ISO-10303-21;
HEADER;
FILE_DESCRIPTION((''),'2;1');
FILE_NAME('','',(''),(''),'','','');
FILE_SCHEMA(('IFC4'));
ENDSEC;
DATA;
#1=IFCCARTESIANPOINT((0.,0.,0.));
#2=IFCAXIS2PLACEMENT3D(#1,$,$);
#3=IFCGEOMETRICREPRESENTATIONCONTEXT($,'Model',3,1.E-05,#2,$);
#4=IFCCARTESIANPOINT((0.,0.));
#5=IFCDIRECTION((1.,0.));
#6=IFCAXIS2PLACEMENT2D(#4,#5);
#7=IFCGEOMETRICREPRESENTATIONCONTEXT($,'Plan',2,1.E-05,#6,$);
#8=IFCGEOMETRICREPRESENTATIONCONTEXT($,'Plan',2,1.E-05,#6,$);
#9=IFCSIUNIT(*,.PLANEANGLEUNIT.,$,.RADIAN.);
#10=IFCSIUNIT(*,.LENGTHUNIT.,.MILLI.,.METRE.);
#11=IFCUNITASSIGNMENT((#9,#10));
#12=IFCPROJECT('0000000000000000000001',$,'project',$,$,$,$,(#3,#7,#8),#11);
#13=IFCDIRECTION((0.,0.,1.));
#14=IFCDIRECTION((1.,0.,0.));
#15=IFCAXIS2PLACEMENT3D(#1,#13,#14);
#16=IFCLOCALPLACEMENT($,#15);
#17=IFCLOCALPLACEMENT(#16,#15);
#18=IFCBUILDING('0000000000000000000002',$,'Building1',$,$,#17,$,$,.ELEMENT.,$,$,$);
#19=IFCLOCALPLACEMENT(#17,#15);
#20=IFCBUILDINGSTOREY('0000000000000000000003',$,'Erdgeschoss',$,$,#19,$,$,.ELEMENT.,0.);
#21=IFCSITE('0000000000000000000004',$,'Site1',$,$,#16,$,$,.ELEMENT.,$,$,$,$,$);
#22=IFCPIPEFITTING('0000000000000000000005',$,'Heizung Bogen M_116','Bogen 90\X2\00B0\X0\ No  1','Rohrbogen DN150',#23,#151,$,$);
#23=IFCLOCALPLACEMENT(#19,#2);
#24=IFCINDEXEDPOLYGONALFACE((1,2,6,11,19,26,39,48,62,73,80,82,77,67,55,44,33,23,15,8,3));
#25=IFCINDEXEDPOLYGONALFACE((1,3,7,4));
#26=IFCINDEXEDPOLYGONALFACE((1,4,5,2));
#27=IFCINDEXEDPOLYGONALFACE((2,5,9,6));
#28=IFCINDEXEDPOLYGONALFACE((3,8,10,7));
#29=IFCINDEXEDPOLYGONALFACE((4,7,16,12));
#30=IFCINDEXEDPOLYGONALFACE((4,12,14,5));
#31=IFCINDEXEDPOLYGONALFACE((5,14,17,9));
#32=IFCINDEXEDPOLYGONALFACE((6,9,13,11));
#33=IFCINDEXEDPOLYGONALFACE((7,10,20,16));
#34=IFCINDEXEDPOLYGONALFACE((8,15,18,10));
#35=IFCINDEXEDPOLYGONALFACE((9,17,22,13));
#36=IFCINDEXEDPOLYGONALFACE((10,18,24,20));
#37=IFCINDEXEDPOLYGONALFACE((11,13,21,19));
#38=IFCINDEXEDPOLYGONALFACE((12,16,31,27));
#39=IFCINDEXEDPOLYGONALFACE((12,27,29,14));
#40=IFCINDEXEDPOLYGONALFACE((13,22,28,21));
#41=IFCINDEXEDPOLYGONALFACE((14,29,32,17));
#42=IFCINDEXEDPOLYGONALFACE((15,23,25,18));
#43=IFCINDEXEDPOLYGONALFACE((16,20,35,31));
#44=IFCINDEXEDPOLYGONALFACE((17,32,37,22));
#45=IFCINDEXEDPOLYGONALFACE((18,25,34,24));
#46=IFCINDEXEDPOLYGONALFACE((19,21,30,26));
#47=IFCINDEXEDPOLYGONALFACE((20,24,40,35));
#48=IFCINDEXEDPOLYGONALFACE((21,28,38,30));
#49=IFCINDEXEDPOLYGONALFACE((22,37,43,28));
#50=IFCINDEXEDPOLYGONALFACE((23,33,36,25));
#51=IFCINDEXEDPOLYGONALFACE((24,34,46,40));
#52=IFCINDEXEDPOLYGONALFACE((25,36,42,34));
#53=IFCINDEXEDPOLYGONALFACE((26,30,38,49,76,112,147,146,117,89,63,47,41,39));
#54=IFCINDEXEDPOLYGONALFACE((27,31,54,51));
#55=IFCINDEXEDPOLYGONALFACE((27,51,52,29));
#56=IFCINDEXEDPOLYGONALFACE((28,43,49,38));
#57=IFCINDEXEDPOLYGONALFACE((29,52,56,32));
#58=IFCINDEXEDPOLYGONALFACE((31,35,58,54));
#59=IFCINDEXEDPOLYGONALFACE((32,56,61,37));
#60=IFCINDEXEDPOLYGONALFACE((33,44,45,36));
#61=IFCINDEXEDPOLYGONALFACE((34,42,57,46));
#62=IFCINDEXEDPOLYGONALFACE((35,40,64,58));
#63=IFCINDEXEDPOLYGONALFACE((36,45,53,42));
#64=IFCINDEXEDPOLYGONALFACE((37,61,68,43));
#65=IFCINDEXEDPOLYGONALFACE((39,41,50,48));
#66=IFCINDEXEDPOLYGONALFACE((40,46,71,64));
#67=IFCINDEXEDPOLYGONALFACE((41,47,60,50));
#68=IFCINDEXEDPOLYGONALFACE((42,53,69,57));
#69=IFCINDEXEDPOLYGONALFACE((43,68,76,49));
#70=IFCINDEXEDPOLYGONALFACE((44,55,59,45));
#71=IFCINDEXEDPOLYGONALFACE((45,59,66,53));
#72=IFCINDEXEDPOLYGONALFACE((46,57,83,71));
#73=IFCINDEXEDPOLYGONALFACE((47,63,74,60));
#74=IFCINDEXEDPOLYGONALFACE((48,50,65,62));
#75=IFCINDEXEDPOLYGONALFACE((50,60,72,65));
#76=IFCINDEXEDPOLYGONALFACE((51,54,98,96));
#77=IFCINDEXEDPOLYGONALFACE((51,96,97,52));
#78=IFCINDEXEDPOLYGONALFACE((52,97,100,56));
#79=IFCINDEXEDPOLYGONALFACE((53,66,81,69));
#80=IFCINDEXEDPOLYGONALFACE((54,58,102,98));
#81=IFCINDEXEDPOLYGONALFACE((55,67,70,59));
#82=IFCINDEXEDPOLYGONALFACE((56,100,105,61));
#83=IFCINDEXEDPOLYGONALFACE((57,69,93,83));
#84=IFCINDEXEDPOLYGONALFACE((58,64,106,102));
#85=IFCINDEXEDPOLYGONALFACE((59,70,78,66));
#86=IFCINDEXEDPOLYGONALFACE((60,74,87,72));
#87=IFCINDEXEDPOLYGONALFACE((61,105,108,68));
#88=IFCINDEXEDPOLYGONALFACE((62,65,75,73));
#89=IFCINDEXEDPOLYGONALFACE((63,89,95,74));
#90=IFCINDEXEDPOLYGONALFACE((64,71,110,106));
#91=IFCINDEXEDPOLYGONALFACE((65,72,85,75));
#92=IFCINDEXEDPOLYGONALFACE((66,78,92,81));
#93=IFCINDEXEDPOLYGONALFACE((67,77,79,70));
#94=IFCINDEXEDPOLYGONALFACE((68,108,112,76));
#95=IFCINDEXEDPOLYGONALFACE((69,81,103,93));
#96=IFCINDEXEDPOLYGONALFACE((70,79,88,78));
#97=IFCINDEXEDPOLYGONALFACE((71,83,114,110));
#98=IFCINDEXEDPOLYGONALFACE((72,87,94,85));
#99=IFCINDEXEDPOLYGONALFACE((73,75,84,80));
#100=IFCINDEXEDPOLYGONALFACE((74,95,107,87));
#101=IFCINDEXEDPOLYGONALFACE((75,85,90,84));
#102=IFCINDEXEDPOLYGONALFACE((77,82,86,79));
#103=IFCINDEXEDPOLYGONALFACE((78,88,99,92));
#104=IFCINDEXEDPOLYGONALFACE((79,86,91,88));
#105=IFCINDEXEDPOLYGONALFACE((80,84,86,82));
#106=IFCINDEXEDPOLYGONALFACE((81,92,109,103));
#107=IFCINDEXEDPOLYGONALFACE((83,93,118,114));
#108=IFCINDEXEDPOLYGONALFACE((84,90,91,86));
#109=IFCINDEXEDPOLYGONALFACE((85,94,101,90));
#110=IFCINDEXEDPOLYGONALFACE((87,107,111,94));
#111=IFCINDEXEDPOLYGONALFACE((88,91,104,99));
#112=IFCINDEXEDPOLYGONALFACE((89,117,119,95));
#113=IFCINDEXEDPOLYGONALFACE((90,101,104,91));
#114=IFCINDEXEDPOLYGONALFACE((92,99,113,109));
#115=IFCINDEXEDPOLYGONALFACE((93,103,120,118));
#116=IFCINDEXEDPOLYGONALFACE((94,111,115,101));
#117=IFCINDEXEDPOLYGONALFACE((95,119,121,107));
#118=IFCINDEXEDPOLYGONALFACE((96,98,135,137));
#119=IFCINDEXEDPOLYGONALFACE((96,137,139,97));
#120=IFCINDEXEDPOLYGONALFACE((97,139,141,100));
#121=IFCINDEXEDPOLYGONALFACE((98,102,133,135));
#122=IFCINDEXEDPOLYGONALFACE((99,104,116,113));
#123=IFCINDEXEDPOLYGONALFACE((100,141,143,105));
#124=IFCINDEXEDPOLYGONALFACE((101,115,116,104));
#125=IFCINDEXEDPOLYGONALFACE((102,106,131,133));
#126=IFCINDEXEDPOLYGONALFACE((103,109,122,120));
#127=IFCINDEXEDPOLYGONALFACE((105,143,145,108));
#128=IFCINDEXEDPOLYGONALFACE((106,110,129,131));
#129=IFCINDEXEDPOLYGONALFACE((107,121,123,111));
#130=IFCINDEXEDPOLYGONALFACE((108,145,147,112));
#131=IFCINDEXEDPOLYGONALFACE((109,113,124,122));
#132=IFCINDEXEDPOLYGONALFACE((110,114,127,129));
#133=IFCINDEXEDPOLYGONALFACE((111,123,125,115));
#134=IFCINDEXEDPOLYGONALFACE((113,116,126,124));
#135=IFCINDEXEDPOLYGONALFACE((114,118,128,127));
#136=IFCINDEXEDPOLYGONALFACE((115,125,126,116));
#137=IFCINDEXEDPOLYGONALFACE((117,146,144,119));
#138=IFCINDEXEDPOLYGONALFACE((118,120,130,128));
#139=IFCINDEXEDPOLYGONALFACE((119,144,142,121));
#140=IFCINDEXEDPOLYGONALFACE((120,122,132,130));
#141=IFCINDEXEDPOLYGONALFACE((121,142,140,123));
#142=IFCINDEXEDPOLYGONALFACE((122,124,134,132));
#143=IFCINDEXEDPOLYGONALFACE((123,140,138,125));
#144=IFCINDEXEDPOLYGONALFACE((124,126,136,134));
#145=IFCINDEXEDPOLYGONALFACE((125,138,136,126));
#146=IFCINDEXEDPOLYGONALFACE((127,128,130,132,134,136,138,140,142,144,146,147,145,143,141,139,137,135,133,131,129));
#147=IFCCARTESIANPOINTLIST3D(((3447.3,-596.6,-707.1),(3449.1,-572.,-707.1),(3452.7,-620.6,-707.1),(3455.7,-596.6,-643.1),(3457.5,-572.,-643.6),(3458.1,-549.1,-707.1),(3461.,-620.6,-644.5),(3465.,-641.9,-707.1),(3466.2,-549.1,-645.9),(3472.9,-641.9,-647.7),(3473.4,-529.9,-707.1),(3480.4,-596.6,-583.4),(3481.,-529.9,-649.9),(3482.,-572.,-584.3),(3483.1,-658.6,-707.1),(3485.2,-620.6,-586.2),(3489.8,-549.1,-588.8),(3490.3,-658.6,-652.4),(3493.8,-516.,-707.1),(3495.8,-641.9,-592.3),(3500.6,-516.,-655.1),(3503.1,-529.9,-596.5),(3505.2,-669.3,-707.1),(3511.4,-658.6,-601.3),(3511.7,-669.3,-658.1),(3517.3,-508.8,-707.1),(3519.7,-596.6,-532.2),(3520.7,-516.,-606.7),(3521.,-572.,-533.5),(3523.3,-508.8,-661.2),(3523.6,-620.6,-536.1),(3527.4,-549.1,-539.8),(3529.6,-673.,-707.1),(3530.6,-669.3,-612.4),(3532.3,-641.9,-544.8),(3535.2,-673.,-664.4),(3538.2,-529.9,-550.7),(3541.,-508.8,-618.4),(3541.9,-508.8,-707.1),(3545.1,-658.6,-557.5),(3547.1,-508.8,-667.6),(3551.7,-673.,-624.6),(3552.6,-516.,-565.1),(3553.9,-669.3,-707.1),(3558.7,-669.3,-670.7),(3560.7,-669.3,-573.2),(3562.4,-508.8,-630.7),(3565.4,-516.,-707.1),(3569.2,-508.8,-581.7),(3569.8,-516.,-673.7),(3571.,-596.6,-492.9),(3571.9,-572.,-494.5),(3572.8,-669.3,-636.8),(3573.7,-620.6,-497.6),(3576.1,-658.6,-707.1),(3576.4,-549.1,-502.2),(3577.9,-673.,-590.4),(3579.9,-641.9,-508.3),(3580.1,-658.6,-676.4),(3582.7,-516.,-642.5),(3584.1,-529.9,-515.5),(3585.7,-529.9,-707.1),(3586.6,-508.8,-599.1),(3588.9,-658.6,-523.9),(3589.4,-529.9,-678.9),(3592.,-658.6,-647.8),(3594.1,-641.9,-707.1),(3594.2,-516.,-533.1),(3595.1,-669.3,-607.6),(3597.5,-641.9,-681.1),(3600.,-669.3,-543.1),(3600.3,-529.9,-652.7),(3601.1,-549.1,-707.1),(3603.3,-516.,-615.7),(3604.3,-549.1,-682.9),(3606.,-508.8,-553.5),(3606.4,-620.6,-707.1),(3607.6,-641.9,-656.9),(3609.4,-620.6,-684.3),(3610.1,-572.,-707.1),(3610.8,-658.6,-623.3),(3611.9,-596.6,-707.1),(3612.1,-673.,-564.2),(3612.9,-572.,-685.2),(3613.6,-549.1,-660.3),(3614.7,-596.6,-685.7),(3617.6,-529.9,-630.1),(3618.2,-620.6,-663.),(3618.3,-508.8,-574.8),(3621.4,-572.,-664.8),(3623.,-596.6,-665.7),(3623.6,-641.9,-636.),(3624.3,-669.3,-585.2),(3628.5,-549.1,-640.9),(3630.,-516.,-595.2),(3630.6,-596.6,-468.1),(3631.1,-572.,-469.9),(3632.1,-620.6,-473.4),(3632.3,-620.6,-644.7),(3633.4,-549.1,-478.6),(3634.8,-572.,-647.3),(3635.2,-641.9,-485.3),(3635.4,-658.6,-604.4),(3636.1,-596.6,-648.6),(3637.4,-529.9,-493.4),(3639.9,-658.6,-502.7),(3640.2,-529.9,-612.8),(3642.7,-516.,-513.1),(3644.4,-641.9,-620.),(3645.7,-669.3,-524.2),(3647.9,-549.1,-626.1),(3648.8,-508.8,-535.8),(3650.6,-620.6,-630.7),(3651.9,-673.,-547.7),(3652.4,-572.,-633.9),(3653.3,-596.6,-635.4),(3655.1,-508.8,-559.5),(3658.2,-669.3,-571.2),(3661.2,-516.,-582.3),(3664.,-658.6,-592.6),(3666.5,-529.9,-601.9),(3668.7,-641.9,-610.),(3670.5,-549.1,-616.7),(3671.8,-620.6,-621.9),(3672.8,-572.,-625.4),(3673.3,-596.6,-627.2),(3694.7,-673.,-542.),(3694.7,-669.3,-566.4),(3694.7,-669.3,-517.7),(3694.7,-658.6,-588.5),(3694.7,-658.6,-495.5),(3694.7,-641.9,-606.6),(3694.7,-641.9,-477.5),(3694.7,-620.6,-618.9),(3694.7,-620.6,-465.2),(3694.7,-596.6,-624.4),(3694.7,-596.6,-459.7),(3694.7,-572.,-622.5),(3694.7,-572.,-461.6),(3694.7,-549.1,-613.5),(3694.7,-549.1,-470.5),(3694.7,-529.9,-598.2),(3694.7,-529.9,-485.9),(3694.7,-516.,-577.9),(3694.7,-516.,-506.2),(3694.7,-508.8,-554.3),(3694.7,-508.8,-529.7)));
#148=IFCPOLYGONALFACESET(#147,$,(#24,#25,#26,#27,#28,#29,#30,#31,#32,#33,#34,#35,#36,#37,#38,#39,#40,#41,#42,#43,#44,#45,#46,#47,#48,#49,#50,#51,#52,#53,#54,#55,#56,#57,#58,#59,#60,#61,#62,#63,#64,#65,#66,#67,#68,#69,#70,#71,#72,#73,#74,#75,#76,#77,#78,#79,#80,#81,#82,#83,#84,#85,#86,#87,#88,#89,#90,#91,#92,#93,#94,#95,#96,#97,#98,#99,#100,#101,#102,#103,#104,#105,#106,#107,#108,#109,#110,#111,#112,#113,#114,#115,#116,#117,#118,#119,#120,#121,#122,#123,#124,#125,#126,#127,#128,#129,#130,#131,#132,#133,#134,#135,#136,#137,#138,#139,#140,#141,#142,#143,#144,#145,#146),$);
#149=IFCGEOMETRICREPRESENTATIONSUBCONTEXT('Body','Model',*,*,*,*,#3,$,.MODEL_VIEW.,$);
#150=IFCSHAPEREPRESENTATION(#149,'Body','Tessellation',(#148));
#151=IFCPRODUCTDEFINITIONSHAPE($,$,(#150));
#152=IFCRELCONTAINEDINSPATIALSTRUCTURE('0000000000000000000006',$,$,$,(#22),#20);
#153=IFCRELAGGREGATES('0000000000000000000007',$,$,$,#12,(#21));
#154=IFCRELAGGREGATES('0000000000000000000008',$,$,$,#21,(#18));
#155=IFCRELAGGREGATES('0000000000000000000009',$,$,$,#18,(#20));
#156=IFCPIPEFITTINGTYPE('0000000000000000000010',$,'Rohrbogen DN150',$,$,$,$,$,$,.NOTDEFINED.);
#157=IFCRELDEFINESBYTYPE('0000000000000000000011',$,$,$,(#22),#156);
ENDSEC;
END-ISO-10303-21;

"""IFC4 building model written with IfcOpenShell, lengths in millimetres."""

from ifc_helpers import new_model, entity, si_unit, frame, origin, origin_with_axes, origin_2d_with_axis, place, context, subcontext, project, spatial, source, transform, mapped, type_object, element, save


model = new_model("IFC4")

# Units and contexts
model_context = context("Model", 3, precision=1e-05, world=origin())
plan_context_1 = context("Plan", 2, precision=1e-05, world=origin_2d_with_axis())
plan_context_2 = context("Plan", 2, precision=1e-05, world=origin_2d_with_axis())
body_context = subcontext(model_context, "Body", "Model", "MODEL_VIEW")
ifc_project = project(units=[si_unit("PLANEANGLEUNIT", "RADIAN"), si_unit("LENGTHUNIT", "METRE", prefix="MILLI")], contexts=[model_context, plan_context_1, plan_context_2])

# Site, building, storey
site_placement = place(None, origin_with_axes())
site = spatial("IfcSite", under=ifc_project, at=site_placement, Name="Site1", CompositionType="ELEMENT")
building_placement = place(site_placement, origin_with_axes())
building = spatial("IfcBuilding", under=site, at=building_placement, Name="Building1", CompositionType="ELEMENT")
storey_placement = place(building_placement, origin_with_axes())
storey = spatial("IfcBuildingStorey", under=building, at=storey_placement, Name="Erdgeschoss", CompositionType="ELEMENT", Elevation=0.0)

# Pipe fitting
pipe_fitting_type_1 = type_object("IfcPipeFittingType", Name="Rohrbogen DN150", PredefinedType="NOTDEFINED")
shared_shape_1 = source(origin_with_axes(), body_context, "Body", "SolidModel", [
    entity("IfcRevolvedAreaSolid", entity("IfcCircleProfileDef", "AREA", None, entity("IfcAxis2Placement2D", entity("IfcCartesianPoint", [0.0, 0.0]), entity("IfcDirection", [1.0, 0.0])), 82.5), entity("IfcAxis2Placement3D", entity("IfcCartesianPoint", [123.8, -41.3, 0.0]), entity("IfcDirection", [-1.0, 0.0, 0.0]), entity("IfcDirection", [0.0, 0.0, 1.0])), entity("IfcAxis1Placement", entity("IfcCartesianPoint", [0.0, 165.1, 0.0]), entity("IfcDirection", [-1.0, 0.0, 0.0])), 1.570796),
])
pipe_fitting_1_placement = place(storey_placement, frame((3570.9, -590.4, -583.3), z_axis=(0.0, 0.0, 1.0), x_axis=(1.0, 0.0, 0.0)))
element("IfcPipeFitting", 1, at=pipe_fitting_1_placement, inside=storey, type_object=pipe_fitting_type_1, Name="Heizung Bogen M_116", Description="Bogen 90° No  1", ObjectType="Rohrbogen DN150", context=body_context, shape_type="MappedRepresentation", body=[
    mapped(shared_shape_1, transform((0.0, 0.0, 0.0), x_axis=(0.0, 0.0, -1.0), y_axis=(1.0, 0.0, 0.0), z_axis=(0.0, -1.0, 0.0), scale=1.0)),
])

save(model, "model.ifc")
